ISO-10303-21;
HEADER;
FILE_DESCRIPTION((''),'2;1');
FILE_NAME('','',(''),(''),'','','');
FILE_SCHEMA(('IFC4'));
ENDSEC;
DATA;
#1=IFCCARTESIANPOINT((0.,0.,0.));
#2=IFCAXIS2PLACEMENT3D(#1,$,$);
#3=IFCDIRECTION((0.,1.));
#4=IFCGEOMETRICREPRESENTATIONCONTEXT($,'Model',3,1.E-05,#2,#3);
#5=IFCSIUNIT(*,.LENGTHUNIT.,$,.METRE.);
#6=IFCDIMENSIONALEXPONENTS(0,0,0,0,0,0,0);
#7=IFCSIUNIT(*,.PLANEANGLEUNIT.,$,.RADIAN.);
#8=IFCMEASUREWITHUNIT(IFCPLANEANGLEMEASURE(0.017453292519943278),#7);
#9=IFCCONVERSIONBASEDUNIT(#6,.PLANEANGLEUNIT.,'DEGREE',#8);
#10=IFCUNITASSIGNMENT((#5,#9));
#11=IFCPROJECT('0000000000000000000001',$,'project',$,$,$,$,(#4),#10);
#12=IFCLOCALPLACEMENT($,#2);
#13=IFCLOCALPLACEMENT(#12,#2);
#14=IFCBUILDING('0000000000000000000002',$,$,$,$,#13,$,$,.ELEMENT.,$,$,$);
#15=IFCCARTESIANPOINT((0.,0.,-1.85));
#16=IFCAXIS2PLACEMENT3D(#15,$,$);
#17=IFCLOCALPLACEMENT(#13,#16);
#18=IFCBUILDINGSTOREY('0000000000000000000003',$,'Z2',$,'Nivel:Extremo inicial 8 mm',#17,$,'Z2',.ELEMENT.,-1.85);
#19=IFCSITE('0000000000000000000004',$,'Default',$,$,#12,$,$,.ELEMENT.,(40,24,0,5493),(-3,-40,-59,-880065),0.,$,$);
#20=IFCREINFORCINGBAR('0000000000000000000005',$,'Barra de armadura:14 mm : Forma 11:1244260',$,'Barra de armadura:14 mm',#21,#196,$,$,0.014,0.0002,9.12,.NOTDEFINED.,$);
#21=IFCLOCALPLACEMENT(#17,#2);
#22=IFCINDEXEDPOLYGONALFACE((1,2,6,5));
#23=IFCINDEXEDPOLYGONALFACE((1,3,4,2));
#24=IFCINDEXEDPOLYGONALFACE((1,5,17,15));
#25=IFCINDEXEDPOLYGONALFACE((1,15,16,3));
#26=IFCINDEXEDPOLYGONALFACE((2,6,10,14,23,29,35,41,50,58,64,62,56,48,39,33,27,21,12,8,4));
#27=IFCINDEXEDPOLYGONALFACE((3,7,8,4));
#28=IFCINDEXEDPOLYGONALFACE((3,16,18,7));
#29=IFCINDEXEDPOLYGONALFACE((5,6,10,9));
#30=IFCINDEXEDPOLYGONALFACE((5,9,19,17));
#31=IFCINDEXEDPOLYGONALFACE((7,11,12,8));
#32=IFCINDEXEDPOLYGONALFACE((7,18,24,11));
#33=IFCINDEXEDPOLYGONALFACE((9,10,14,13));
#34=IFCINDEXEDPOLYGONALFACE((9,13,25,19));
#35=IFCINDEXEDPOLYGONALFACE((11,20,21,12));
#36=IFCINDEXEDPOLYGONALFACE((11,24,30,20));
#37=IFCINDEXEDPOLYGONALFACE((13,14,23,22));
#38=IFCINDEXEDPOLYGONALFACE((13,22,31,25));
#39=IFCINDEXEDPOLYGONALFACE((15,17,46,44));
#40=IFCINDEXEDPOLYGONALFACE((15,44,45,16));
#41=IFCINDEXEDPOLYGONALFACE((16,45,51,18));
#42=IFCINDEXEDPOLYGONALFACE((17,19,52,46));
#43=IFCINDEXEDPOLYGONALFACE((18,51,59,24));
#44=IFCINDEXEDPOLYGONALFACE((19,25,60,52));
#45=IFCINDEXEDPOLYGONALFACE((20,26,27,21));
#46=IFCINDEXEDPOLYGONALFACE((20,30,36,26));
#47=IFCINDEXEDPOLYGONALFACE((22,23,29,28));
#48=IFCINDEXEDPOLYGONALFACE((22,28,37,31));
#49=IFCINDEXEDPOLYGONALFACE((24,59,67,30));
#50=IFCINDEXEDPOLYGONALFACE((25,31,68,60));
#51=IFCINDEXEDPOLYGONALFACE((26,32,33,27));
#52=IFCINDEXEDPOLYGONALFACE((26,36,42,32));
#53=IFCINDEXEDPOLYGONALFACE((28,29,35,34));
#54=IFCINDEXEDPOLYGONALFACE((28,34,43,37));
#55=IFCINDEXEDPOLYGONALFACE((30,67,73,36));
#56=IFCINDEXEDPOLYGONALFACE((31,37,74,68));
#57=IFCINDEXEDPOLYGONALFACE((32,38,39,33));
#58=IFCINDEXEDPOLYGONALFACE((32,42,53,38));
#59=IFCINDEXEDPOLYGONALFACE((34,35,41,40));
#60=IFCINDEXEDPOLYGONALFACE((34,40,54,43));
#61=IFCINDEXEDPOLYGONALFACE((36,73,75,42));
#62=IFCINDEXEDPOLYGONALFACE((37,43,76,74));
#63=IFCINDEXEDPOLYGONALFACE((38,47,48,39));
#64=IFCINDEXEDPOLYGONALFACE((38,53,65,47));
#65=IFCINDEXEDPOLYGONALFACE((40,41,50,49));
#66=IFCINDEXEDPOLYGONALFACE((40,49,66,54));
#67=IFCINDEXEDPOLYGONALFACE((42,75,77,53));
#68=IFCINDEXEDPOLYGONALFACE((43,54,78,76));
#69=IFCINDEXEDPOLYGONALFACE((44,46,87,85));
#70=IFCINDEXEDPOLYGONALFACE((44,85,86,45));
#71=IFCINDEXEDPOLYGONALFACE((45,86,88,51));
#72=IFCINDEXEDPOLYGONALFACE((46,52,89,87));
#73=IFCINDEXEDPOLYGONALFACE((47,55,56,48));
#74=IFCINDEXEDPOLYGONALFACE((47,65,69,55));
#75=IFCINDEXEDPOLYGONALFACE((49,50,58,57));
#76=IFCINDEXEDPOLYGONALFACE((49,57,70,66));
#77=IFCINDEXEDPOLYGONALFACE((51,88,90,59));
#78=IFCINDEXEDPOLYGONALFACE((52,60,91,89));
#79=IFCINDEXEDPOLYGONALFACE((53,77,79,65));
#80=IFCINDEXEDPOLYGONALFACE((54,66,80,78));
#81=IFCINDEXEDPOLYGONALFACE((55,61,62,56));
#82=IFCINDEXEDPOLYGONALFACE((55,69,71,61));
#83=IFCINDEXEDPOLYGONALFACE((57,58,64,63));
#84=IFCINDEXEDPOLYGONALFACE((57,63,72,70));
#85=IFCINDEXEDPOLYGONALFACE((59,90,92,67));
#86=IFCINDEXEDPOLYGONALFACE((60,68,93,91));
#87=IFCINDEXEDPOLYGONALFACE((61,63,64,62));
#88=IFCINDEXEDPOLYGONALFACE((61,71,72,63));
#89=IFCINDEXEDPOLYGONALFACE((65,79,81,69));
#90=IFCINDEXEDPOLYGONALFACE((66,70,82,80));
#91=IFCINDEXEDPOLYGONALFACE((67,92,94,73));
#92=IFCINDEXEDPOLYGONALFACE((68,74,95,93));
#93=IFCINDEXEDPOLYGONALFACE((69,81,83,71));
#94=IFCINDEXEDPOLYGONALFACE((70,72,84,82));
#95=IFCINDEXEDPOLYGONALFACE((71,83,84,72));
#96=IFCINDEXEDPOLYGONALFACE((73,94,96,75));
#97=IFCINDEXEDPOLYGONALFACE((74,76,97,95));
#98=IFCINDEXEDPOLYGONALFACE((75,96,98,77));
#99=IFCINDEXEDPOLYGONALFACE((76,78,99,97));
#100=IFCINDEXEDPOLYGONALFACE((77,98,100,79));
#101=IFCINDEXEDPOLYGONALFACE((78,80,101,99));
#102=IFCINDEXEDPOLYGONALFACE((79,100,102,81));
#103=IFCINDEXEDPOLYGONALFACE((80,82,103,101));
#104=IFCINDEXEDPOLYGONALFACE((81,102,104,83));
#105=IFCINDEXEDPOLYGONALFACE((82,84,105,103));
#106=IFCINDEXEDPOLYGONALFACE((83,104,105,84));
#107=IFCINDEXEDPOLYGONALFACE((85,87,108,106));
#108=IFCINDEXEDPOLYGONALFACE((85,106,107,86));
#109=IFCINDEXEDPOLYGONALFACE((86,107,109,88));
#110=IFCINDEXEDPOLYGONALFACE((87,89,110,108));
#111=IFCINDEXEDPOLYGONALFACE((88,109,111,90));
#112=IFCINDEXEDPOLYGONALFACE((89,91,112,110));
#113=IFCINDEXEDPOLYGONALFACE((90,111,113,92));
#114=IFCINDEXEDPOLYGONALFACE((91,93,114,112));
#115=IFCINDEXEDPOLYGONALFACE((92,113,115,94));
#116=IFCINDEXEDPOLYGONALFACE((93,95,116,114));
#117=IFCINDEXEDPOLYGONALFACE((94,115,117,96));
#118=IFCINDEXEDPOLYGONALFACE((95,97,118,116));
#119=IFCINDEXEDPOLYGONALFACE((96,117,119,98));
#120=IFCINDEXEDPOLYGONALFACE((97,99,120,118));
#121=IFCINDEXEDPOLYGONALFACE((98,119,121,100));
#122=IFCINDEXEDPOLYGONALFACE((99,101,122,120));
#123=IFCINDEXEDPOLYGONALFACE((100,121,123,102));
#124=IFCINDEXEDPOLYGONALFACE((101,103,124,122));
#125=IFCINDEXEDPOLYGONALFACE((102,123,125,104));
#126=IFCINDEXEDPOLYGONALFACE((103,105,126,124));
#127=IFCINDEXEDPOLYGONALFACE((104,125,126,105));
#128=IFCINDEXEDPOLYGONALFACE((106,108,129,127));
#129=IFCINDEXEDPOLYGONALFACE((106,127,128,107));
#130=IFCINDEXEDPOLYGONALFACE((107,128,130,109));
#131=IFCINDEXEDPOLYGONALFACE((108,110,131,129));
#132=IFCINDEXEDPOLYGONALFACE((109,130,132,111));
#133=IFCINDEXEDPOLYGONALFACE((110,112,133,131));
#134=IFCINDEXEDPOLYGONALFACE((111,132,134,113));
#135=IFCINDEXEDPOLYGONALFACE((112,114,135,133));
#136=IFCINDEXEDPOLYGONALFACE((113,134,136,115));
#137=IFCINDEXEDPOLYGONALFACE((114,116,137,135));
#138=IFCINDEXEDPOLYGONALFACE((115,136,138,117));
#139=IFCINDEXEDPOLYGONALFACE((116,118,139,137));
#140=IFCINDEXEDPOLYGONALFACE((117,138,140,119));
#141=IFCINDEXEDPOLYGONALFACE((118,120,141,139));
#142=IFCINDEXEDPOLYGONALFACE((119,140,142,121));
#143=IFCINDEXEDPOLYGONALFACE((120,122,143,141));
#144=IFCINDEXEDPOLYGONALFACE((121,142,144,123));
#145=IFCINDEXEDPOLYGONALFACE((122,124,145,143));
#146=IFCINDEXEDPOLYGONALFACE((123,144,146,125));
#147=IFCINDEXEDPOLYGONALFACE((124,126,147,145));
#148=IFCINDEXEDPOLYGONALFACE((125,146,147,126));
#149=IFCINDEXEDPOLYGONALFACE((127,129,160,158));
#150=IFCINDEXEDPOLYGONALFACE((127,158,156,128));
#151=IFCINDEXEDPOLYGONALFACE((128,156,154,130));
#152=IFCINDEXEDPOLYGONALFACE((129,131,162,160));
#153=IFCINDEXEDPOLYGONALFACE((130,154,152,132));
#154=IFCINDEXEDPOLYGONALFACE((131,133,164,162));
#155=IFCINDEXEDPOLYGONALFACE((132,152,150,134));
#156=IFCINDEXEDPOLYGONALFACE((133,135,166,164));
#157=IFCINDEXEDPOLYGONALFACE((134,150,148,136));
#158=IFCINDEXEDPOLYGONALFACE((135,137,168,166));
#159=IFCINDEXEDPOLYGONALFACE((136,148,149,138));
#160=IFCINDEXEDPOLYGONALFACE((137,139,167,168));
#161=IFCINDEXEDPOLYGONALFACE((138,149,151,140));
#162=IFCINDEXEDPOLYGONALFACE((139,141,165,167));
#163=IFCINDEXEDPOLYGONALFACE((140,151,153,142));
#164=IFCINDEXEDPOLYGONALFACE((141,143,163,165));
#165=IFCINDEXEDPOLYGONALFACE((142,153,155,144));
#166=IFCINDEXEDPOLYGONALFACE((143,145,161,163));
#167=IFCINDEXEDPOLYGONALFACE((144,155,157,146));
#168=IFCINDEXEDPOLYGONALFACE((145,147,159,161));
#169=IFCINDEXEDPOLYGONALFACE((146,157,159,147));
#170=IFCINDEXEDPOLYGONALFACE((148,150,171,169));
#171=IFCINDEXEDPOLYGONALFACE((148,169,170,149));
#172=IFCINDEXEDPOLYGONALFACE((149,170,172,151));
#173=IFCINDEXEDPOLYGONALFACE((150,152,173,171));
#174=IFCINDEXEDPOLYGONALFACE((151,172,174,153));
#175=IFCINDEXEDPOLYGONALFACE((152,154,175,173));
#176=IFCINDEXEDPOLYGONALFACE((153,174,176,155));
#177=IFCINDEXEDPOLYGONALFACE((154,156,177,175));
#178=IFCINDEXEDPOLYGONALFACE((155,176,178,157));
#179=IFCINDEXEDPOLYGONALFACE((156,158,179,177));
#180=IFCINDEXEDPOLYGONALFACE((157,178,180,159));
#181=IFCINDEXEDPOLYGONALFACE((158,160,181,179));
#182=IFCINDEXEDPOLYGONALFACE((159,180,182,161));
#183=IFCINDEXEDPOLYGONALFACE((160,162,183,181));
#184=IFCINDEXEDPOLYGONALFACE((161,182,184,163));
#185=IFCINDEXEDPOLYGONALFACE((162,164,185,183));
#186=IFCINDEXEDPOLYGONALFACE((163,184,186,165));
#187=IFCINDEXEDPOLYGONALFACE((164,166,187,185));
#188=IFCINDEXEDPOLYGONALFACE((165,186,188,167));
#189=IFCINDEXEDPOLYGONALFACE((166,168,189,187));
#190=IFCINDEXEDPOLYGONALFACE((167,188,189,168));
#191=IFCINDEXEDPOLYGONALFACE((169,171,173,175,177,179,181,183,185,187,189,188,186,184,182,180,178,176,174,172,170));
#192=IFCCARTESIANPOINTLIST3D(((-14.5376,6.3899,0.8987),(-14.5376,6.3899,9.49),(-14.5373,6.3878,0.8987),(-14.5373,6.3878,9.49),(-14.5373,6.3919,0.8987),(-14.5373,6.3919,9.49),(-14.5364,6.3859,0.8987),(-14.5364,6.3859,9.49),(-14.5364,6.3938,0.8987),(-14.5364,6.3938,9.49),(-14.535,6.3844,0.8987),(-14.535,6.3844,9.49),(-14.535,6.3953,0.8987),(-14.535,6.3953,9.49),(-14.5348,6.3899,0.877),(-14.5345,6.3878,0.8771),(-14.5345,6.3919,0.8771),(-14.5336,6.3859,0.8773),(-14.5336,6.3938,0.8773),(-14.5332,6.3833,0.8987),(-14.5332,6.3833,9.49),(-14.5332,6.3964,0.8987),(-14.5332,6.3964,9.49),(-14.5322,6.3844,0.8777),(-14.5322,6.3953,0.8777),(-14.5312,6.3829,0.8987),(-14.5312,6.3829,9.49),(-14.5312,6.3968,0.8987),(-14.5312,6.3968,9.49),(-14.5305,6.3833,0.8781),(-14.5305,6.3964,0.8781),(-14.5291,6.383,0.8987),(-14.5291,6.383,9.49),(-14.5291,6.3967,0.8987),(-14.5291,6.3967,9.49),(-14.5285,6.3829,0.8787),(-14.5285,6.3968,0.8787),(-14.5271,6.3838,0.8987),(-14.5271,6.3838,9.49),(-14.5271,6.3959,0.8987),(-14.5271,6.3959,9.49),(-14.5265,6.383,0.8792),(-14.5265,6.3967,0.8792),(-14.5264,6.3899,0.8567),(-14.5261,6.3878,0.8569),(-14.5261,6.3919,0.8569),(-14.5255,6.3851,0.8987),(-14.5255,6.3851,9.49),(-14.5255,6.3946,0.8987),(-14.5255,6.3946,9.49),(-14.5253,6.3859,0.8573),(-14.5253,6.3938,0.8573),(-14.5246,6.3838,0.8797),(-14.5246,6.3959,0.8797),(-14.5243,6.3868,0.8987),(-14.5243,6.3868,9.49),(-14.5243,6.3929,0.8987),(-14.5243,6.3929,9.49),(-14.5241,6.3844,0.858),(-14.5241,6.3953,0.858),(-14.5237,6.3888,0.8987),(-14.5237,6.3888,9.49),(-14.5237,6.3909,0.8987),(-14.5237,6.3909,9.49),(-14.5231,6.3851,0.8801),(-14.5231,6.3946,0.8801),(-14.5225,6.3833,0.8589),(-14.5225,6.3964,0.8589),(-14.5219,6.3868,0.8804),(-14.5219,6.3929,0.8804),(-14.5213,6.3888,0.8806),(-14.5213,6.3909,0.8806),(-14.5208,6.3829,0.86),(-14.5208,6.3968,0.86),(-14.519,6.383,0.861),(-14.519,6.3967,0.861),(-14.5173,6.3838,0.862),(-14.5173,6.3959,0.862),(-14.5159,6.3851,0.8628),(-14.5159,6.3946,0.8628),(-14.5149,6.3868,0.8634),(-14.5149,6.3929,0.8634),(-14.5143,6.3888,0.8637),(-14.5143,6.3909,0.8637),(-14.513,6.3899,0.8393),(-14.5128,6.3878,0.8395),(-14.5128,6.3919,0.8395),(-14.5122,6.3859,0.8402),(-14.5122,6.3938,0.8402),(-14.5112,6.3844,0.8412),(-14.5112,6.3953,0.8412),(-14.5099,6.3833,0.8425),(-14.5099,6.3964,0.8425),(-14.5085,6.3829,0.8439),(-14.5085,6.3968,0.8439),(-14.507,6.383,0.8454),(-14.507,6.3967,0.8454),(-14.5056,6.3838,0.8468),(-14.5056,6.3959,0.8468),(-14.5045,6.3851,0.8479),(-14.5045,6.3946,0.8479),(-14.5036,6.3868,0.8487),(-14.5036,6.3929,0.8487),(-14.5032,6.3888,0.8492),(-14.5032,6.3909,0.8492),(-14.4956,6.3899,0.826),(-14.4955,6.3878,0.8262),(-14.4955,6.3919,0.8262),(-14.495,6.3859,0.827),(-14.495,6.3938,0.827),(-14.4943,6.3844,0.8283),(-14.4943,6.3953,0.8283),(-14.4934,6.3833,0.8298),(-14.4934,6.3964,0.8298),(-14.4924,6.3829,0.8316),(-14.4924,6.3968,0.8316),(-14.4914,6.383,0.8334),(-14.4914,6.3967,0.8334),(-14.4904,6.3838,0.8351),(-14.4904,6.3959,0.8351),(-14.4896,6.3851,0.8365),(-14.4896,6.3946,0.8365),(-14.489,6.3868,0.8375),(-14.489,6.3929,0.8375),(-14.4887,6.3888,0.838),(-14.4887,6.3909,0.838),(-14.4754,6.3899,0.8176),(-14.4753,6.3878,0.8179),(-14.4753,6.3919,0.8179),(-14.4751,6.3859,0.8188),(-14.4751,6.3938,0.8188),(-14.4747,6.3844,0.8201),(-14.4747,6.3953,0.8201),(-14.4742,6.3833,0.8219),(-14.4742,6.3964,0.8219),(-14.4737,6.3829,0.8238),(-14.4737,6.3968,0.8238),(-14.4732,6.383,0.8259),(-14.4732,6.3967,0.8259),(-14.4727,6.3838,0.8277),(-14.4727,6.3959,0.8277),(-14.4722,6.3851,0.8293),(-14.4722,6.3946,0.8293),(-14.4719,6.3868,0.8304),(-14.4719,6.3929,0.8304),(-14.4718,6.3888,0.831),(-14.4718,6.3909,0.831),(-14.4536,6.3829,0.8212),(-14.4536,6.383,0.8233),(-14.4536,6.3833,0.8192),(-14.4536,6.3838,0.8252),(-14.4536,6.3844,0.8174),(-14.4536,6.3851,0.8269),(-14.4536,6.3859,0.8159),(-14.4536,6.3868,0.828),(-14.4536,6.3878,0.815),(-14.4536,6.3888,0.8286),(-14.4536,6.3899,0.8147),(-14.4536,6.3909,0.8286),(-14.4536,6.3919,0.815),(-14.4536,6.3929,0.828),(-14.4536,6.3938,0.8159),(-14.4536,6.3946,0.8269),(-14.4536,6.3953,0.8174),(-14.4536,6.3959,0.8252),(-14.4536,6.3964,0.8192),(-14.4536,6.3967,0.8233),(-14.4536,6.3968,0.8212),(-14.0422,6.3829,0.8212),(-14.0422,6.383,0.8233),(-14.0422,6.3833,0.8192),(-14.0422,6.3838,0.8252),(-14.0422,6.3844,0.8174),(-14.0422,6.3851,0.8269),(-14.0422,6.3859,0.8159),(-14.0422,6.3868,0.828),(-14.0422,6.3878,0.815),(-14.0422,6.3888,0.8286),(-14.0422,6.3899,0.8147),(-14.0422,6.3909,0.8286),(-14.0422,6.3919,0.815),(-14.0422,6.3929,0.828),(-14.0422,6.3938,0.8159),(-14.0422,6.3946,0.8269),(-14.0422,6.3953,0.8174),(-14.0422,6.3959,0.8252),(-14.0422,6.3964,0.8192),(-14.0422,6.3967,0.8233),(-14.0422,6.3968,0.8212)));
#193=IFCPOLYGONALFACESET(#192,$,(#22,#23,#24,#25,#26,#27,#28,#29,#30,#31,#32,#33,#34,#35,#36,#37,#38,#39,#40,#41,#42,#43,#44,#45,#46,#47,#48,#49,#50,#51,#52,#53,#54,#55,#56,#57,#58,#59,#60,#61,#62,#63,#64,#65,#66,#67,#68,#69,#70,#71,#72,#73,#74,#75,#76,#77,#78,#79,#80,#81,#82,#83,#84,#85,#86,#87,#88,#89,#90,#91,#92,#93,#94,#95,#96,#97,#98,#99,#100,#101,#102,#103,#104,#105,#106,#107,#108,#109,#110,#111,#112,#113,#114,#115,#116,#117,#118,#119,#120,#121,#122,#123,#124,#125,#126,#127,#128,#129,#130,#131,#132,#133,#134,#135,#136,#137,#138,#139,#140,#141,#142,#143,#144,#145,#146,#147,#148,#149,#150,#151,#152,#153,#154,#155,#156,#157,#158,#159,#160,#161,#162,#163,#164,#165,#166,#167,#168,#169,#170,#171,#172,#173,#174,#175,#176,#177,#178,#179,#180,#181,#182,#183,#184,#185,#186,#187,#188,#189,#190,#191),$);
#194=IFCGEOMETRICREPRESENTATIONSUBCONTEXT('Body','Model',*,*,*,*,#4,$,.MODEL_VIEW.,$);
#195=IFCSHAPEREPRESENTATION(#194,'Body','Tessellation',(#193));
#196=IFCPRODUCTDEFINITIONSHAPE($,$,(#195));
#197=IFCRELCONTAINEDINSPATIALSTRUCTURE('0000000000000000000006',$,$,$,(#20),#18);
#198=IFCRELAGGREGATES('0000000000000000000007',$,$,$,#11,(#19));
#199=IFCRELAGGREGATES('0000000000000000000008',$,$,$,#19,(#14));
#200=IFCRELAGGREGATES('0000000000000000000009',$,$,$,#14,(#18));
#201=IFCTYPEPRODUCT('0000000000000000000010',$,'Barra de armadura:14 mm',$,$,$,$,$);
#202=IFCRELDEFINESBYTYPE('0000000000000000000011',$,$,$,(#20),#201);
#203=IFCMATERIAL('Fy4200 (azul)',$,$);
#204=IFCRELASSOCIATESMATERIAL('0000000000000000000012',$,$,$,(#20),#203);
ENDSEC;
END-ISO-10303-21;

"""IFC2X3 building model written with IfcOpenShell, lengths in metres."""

from ifc_helpers import new_model, entity, si_unit, converted_unit, direction, frame, origin, place, context, subcontext, project, spatial, material, type_object, element, save


model = new_model("IFC2X3")

# Units and contexts
model_context = context("Model", 3, precision=1e-05, world=origin(), true_north=direction((0.0, 1.0)))
body_context = subcontext(model_context, "Body", "Model", "MODEL_VIEW")
ifc_project = project(units=[si_unit("LENGTHUNIT", "METRE"), converted_unit("PLANEANGLEUNIT", "DEGREE", entity("IfcPlaneAngleMeasure", 0.017453292519943278), si_unit("PLANEANGLEUNIT", "RADIAN"), dimensions=[0, 0, 0, 0, 0, 0, 0])], contexts=[model_context])

# Site, building, storey
site_placement = place(None, origin())
site = spatial("IfcSite", under=ifc_project, at=site_placement, Name="Default", CompositionType="ELEMENT", RefLatitude=(40, 24, 0, 5493), RefLongitude=(-3, -40, -59, -880065), RefElevation=0.0)
building_placement = place(site_placement, origin())
building = spatial("IfcBuilding", under=site, at=building_placement, CompositionType="ELEMENT")
storey_placement = place(building_placement, frame((0.0, 0.0, -1.85)))
storey = spatial("IfcBuildingStorey", under=building, at=storey_placement, Name="Z2", ObjectType="Nivel:Extremo inicial 8 mm", LongName="Z2", CompositionType="ELEMENT", Elevation=-1.85)

# Reinforcing bar
ifc_material_1 = material(Name="Fy4200 (azul)")
type_product_1 = type_object("IfcTypeProduct", Name="Barra de armadura:14 mm")
reinforcing_bar_1_placement = place(storey_placement, origin())
element("IfcReinforcingBar", 1, at=reinforcing_bar_1_placement, inside=storey, type_object=type_product_1, material=ifc_material_1, Name="Barra de armadura:14 mm : Forma 11:1244260", ObjectType="Barra de armadura:14 mm", BarLength=9.12, BarRole="NOTDEFINED", CrossSectionArea=0.0002, NominalDiameter=0.014, context=body_context, shape_type="AdvancedSweptSolid", body=[
    entity("IfcSweptDiskSolid", entity("IfcCompositeCurve", [entity("IfcCompositeCurveSegment", "CONTINUOUS", True, entity("IfcPolyline", [entity("IfcCartesianPoint", [-14.5306, 6.3899, 9.49]), entity("IfcCartesianPoint", [-14.5306, 6.3899, 0.8987])])), entity("IfcCompositeCurveSegment", "CONTINUOUS", True, entity("IfcTrimmedCurve", entity("IfcCircle", entity("IfcAxis2Placement3D", entity("IfcCartesianPoint", [-14.4536, 6.3899, 0.8987]), entity("IfcDirection", [0.0, -1.0, 0.0]), entity("IfcDirection", [0.0, 0.0, -1.0])), 0.077), [entity("IfcParameterValue", 270.0)], [entity("IfcParameterValue", 360.0)], True, "PARAMETER")), entity("IfcCompositeCurveSegment", "CONTINUOUS", True, entity("IfcPolyline", [entity("IfcCartesianPoint", [-14.4536, 6.3899, 0.8217]), entity("IfcCartesianPoint", [-14.0422, 6.3899, 0.8217])]))], False), 0.007, None, 0.0, 92.0),
])

save(model, "model.ifc")
